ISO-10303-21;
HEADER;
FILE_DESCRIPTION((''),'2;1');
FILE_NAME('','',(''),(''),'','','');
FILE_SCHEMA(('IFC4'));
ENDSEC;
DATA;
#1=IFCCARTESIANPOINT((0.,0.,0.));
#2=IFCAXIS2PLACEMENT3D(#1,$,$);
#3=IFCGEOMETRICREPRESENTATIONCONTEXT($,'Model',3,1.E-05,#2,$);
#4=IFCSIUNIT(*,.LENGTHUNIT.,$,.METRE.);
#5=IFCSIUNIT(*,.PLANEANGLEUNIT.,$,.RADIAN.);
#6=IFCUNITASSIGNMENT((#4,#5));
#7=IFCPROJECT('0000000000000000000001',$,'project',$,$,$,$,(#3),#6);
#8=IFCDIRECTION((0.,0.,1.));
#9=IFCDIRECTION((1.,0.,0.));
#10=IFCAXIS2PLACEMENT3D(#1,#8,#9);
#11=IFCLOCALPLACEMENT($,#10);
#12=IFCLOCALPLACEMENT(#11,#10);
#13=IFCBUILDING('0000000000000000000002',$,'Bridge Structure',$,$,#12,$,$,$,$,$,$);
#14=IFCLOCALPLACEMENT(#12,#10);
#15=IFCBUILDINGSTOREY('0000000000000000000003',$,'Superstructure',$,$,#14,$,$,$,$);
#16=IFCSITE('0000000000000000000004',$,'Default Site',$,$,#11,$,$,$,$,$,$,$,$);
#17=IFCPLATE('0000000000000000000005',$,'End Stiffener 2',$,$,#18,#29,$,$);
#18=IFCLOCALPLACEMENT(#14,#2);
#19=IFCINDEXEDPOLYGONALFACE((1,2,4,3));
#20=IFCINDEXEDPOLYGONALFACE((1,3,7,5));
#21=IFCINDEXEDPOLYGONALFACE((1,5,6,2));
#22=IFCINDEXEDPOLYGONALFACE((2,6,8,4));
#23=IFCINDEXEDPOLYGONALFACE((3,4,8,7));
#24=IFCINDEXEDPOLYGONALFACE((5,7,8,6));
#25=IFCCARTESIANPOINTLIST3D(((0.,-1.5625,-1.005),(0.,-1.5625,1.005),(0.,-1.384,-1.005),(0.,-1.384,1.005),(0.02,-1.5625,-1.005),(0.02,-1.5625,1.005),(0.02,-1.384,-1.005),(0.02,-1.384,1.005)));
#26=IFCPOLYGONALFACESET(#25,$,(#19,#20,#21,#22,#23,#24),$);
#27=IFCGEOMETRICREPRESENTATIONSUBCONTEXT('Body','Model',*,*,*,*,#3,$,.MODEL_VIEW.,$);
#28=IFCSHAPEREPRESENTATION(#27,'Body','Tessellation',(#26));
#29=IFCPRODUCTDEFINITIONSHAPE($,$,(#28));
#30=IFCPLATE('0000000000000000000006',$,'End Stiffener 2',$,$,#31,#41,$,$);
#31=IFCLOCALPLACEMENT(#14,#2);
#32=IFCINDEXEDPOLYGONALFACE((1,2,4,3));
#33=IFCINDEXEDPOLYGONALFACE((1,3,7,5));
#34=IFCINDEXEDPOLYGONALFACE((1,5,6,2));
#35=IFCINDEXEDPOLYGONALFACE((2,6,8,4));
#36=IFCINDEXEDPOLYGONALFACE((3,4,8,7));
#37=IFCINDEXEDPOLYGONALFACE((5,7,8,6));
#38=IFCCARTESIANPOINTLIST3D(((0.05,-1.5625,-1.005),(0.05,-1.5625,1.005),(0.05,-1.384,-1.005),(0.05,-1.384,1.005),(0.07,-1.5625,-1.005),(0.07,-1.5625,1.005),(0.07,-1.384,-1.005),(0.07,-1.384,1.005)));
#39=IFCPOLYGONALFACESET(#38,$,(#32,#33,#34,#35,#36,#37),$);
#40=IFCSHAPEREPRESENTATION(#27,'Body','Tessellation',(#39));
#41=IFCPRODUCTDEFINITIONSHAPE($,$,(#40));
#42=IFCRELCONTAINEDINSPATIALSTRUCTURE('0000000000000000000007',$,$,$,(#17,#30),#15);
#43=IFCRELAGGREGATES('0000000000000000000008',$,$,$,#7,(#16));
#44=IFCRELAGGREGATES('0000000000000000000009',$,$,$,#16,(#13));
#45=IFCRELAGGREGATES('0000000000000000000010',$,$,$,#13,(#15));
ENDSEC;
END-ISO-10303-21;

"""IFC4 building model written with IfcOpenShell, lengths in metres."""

from ifc_helpers import new_model, si_unit, frame, origin, origin_with_axes, origin_2d_with_axis, place, context, subcontext, project, spatial, rectangle, extrude, element, save


model = new_model("IFC4")

# Units and contexts
model_context = context("Model", 3, precision=1e-05, world=origin())
body_context = subcontext(model_context, "Body", "Model", "MODEL_VIEW")
ifc_project = project(units=[si_unit("LENGTHUNIT", "METRE"), si_unit("PLANEANGLEUNIT", "RADIAN")], contexts=[model_context])

# Site, building, storey
site_placement = place(None, origin_with_axes())
site = spatial("IfcSite", under=ifc_project, at=site_placement, Name="Default Site")
building_placement = place(site_placement, origin_with_axes())
building = spatial("IfcBuilding", under=site, at=building_placement, Name="Bridge Structure")
storey_placement = place(building_placement, origin_with_axes())
storey = spatial("IfcBuildingStorey", under=building, at=storey_placement, Name="Superstructure")

# Plates
for number, where, z_axis, x_axis, name in (
    (1, (0.01, -1.4732, -1.005), (0.0, 0.0, 1.0), (1.0, 0.0, 0.0), "End Stiffener 2"),
    (2, (0.06, -1.4732, -1.005), (0.0, 0.0, 1.0), (1.0, 0.0, 0.0), "End Stiffener 2"),
):
    element("IfcPlate", number, at=place(storey_placement, frame(where, z_axis=z_axis, x_axis=x_axis)), inside=storey, Name=name, context=body_context, shape_type="SweptSolid", body=[
        extrude(rectangle(XDim=0.02, YDim=0.1785, at=origin_2d_with_axis()), origin_with_axes(), (0.0, 0.0, 1.0), 2.01),
    ])

save(model, "model.ifc")
